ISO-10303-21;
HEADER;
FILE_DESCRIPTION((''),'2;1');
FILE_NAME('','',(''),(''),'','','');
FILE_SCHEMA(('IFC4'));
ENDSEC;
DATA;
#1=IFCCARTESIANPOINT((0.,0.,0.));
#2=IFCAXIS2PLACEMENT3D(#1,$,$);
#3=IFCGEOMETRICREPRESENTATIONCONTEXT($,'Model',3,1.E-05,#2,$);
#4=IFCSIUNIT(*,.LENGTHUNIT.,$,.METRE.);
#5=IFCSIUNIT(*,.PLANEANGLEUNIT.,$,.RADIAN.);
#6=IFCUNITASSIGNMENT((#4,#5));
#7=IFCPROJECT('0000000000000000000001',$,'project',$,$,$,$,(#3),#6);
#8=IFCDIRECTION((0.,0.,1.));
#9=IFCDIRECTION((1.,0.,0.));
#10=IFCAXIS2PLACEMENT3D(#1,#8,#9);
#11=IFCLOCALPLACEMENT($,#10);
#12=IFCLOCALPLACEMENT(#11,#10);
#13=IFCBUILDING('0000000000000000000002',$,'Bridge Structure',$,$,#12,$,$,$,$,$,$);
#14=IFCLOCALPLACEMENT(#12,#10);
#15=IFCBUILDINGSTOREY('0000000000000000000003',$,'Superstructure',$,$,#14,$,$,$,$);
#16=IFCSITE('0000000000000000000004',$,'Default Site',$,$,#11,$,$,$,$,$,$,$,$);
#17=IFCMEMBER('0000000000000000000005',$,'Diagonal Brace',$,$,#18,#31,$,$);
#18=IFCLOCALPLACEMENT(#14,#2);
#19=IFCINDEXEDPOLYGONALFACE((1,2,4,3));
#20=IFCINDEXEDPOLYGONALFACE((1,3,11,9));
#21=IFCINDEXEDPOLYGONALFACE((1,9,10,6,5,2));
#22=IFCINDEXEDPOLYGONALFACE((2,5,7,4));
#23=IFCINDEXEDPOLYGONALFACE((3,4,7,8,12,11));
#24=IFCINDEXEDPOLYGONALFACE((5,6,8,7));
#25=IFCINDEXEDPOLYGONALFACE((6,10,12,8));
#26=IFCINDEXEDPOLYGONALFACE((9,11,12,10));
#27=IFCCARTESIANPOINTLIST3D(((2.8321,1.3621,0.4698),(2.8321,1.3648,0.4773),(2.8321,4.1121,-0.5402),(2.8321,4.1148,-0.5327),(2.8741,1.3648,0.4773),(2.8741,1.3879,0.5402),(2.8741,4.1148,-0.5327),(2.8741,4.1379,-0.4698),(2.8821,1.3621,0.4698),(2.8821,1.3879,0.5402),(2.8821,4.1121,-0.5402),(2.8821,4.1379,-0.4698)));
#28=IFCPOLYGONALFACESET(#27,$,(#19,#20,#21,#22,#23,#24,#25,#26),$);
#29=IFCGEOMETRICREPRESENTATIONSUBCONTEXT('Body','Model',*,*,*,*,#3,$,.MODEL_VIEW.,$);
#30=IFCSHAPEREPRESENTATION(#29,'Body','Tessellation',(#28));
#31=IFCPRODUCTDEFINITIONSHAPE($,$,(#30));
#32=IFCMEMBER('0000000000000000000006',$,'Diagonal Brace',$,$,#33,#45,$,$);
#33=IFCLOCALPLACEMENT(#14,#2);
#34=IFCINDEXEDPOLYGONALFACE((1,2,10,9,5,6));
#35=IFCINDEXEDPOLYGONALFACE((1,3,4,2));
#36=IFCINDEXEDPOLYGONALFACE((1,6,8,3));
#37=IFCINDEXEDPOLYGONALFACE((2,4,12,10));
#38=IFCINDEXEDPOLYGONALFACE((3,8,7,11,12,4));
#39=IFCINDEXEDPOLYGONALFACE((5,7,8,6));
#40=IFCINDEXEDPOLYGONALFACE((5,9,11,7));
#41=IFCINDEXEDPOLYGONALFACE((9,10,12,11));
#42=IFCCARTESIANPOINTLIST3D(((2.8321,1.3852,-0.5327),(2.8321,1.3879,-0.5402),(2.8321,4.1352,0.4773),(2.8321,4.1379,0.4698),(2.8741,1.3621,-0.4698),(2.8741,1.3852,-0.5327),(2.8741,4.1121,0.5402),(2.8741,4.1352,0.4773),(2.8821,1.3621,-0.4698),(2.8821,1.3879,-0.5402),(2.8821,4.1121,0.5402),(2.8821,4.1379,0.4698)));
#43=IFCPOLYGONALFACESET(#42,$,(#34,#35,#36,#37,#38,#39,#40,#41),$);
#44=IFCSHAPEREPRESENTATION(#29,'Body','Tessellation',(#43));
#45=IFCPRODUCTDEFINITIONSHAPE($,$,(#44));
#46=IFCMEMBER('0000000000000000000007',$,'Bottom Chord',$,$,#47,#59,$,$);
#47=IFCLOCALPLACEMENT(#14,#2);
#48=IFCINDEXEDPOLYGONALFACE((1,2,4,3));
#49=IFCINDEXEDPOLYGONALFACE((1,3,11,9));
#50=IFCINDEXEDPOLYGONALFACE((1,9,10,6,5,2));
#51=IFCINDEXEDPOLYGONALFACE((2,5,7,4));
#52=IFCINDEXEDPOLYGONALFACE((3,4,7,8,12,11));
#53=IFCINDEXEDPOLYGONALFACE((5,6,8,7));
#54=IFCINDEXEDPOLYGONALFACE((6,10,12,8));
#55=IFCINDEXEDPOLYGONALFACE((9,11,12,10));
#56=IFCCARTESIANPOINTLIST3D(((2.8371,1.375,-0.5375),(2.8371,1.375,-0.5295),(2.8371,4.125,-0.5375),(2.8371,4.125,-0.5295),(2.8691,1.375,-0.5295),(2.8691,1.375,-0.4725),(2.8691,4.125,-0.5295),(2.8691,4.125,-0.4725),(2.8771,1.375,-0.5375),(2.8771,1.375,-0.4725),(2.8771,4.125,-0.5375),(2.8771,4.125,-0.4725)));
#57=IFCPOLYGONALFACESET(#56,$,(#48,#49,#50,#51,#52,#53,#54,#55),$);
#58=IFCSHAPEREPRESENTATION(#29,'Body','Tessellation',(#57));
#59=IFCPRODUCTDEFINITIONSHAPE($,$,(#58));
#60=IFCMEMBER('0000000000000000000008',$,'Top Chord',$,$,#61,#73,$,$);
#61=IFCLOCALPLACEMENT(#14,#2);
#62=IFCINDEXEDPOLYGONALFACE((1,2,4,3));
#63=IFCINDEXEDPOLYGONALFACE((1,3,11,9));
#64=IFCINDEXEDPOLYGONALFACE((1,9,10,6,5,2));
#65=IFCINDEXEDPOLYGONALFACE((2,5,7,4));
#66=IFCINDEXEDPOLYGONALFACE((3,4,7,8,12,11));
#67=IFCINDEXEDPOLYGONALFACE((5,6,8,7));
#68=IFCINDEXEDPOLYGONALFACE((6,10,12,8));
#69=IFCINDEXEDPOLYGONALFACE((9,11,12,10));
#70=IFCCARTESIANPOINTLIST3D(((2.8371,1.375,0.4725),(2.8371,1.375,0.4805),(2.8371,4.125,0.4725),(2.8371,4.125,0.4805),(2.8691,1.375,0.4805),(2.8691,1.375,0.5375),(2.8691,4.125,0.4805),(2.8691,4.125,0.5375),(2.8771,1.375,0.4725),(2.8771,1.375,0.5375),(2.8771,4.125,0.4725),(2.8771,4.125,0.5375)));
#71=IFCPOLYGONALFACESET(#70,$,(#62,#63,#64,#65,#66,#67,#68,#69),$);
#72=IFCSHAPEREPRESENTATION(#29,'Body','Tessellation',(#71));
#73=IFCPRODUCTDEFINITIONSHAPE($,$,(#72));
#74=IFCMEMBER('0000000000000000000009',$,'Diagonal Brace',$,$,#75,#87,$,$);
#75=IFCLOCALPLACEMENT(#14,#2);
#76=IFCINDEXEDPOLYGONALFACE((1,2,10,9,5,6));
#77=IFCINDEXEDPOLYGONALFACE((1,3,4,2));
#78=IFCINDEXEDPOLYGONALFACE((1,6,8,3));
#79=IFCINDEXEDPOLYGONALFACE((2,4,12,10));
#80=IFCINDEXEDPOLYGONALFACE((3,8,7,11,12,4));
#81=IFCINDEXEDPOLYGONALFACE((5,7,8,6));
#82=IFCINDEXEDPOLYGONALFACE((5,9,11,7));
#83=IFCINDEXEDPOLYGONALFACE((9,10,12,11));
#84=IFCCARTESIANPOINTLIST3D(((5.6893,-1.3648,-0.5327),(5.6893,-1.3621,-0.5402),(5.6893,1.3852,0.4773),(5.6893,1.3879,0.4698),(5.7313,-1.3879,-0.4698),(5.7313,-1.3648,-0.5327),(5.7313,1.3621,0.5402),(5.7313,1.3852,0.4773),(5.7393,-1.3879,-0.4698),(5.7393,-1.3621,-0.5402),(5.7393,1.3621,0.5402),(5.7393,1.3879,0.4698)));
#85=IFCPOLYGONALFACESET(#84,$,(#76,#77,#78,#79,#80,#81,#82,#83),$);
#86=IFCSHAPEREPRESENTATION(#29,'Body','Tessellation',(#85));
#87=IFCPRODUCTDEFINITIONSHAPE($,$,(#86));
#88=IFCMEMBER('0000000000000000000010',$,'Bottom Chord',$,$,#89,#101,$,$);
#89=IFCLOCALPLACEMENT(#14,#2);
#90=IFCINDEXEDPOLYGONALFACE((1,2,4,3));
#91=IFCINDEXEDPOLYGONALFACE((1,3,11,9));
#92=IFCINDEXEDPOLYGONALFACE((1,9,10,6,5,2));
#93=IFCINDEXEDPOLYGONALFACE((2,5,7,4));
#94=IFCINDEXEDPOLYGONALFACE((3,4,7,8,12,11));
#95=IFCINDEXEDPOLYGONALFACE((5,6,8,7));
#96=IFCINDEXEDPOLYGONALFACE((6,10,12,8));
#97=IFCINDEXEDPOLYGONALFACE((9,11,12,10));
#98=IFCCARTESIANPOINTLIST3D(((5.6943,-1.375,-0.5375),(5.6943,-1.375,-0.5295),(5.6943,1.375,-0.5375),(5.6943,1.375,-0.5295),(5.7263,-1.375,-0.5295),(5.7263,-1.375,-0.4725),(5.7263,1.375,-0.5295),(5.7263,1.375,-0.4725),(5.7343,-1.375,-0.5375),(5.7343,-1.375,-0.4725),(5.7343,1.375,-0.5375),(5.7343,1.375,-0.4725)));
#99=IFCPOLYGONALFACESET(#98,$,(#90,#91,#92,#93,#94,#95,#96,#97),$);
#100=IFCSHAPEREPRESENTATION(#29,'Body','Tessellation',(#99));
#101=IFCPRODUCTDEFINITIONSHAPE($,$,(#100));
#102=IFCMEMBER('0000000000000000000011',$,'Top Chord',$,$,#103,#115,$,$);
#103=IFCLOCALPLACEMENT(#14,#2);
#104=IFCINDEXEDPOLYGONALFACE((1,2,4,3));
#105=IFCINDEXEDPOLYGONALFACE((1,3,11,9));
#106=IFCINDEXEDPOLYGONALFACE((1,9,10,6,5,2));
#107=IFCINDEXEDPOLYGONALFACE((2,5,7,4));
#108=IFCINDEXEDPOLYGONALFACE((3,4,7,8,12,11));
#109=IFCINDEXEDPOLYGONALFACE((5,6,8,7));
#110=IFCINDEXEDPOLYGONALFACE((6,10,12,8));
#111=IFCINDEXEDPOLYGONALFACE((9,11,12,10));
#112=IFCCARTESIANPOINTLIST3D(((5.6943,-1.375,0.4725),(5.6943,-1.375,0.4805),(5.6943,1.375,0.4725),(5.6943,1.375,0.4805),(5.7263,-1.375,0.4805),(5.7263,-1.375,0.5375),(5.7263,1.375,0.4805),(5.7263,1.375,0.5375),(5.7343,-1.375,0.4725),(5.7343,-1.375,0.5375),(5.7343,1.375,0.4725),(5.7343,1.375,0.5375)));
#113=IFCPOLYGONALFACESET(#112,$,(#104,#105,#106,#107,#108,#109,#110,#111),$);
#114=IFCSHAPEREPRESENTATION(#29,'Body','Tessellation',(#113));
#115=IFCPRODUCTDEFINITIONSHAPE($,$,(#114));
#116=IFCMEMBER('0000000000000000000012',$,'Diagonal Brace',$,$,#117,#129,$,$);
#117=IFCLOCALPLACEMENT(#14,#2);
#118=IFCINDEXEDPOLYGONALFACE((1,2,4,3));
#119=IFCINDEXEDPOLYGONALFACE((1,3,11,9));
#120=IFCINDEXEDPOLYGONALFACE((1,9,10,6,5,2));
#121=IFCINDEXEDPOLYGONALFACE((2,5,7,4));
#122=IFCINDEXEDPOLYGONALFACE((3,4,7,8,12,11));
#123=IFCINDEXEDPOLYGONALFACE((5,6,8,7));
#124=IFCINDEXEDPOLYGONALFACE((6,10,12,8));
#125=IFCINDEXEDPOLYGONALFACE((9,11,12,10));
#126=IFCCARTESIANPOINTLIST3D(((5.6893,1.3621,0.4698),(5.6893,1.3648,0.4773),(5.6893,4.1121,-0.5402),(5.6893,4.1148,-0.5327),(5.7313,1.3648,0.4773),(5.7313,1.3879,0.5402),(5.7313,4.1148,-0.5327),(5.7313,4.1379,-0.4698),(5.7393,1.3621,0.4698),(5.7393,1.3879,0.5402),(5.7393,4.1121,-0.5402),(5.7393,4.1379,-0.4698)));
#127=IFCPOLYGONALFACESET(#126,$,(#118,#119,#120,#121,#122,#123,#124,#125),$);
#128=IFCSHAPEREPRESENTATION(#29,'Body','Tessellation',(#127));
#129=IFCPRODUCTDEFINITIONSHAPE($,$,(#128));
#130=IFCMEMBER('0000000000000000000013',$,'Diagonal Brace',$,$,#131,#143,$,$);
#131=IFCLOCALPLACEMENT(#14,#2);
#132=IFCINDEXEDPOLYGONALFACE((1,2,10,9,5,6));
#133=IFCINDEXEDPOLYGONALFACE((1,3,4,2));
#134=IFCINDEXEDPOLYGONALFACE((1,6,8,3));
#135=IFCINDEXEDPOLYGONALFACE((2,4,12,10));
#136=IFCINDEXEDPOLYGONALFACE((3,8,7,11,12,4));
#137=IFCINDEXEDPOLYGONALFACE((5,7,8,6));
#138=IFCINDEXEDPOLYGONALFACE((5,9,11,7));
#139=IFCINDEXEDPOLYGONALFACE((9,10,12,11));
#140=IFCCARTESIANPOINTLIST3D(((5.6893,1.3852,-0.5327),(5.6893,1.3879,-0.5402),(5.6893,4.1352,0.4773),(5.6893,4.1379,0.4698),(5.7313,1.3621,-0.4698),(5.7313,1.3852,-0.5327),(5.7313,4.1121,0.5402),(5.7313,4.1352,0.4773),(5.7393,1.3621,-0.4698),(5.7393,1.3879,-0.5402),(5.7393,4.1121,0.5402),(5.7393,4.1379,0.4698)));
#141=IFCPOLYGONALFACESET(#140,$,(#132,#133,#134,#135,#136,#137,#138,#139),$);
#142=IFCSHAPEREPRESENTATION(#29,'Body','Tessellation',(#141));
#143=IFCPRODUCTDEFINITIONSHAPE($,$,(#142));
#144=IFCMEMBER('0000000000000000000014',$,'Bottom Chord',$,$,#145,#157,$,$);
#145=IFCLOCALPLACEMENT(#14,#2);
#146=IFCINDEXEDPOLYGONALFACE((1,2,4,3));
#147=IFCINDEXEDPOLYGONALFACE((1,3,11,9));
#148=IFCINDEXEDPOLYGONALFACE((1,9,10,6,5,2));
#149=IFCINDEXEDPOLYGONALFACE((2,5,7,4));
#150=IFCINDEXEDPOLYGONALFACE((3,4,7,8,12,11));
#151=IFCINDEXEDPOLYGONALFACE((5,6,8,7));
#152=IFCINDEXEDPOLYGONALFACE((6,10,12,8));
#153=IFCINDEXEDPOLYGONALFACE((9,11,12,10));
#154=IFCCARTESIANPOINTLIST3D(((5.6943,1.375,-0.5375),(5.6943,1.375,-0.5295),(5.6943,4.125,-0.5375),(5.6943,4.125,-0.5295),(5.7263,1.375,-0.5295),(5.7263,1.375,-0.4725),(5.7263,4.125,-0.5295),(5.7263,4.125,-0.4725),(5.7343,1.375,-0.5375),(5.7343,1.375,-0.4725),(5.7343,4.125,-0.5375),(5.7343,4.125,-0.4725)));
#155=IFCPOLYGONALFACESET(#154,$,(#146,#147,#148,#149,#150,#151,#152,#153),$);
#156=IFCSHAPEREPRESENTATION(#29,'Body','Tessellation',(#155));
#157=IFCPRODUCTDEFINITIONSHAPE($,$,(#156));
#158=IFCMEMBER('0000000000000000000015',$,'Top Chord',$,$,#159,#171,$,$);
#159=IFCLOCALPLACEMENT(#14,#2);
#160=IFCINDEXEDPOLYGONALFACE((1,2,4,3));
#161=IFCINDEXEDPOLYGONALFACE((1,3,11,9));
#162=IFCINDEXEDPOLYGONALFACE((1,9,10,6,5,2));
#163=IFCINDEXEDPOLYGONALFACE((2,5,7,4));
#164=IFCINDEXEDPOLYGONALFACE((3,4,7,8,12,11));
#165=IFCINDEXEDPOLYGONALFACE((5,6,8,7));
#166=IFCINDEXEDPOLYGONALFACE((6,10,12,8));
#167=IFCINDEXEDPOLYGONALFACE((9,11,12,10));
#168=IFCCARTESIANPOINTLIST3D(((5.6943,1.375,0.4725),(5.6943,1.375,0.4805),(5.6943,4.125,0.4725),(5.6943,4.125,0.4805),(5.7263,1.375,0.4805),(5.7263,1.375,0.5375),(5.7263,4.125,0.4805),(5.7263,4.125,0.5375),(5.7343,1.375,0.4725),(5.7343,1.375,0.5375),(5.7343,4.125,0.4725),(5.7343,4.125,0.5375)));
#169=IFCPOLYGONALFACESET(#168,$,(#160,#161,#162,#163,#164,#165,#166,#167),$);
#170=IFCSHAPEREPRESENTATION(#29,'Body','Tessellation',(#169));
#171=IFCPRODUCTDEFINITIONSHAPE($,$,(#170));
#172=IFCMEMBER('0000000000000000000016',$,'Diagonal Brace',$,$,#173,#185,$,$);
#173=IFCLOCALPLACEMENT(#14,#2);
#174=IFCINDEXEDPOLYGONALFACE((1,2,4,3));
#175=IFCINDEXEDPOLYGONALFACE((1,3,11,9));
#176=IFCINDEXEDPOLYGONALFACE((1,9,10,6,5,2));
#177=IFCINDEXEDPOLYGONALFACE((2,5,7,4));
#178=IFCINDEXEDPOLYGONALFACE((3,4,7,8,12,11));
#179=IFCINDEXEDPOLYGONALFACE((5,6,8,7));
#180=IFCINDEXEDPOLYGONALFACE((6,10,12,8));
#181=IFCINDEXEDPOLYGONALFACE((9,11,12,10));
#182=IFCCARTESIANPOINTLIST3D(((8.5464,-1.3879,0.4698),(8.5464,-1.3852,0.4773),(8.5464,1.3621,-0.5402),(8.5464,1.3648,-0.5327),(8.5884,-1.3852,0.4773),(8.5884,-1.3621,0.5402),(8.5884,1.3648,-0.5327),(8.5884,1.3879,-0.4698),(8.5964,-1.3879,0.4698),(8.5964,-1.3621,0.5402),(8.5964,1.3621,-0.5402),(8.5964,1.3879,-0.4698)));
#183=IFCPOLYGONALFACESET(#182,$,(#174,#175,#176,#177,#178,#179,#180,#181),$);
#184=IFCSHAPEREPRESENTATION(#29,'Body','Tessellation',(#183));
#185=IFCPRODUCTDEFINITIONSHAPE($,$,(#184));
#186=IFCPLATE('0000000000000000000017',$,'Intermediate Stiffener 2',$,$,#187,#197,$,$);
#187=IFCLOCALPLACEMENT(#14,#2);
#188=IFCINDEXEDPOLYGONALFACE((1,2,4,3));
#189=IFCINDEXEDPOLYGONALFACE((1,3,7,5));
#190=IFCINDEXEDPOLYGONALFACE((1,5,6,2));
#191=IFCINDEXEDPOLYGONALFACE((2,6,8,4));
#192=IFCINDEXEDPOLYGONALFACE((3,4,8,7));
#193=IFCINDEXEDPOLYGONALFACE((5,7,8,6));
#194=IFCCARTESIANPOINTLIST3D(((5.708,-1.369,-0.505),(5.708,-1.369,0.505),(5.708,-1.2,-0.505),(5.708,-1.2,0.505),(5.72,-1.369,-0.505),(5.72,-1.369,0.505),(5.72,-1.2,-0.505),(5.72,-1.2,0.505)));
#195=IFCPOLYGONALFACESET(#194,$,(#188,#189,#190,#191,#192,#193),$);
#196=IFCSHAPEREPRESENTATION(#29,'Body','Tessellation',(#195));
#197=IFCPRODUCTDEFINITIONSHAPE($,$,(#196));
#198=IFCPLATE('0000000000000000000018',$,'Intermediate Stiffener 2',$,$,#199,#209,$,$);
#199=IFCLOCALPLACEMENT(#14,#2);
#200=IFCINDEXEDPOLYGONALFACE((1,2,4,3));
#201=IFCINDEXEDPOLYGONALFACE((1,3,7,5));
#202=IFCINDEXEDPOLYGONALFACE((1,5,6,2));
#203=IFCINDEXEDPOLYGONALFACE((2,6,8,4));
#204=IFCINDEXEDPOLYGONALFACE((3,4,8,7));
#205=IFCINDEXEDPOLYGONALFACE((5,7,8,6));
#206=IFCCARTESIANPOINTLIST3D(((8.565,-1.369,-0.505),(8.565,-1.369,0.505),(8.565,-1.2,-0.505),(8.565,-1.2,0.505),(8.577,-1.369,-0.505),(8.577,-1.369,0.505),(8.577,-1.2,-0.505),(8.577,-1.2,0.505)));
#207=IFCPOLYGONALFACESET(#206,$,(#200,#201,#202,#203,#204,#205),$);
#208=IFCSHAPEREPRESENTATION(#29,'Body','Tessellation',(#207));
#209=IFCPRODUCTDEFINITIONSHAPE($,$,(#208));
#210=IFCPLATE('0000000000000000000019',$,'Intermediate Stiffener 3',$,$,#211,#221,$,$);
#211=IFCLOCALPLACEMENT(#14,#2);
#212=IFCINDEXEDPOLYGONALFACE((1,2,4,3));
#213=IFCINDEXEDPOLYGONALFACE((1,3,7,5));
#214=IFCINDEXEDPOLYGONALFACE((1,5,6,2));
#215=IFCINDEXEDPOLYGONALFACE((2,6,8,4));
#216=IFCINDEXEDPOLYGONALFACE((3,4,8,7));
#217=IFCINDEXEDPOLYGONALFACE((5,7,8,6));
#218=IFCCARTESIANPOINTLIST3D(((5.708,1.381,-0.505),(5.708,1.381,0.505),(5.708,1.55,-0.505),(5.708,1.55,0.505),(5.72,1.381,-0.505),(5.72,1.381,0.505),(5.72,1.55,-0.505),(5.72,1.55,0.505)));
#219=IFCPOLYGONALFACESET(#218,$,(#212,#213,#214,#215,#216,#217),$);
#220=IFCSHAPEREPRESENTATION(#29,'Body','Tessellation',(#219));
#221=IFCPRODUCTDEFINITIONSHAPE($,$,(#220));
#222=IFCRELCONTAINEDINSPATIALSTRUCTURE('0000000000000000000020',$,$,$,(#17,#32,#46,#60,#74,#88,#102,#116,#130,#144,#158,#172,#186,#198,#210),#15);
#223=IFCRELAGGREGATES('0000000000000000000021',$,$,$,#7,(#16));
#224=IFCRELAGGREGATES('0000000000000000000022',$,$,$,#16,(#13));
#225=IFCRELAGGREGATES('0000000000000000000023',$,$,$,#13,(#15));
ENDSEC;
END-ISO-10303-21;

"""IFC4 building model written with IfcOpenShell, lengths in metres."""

from ifc_helpers import new_model, si_unit, frame, origin, origin_with_axes, origin_2d_with_axis, place, context, subcontext, project, spatial, rectangle, l_section, extrude, element, save


model = new_model("IFC4")

# Units and contexts
model_context = context("Model", 3, precision=1e-05, world=origin())
body_context = subcontext(model_context, "Body", "Model", "MODEL_VIEW")
ifc_project = project(units=[si_unit("LENGTHUNIT", "METRE"), si_unit("PLANEANGLEUNIT", "RADIAN")], contexts=[model_context])

# Site, building, storey
site_placement = place(None, origin_with_axes())
site = spatial("IfcSite", under=ifc_project, at=site_placement, Name="Default Site")
building_placement = place(site_placement, origin_with_axes())
building = spatial("IfcBuilding", under=site, at=building_placement, Name="Bridge Structure")
storey_placement = place(building_placement, origin_with_axes())
storey = spatial("IfcBuildingStorey", under=building, at=storey_placement, Name="Superstructure")

# Members
for number, where, z_axis, x_axis, name in (
    (1, (2.8571, 1.375, 0.505), (0.0, 0.938692, -0.344756), (-1.0, 0.0, 0.0), "Diagonal Brace"),
    (2, (2.8571, 1.375, -0.505), (0.0, 0.938692, 0.344756), (-1.0, 0.0, 0.0), "Diagonal Brace"),
):
    element("IfcMember", number, at=place(storey_placement, frame(where, z_axis=z_axis, x_axis=x_axis)), inside=storey, Name=name, context=body_context, shape_type="SweptSolid", body=[
        extrude(l_section(Depth=0.075, Width=0.05, Thickness=0.008, at=origin_2d_with_axis()), origin_with_axes(), (0.0, 0.0, 1.0), 2.9296),
    ])
for number, where, z_axis, x_axis, name in (
    (3, (2.8571, 1.375, -0.505), (0.0, 1.0, 0.0), (-1.0, 0.0, 0.0), "Bottom Chord"),
    (4, (2.8571, 1.375, 0.505), (0.0, 1.0, 0.0), (-1.0, 0.0, 0.0), "Top Chord"),
):
    element("IfcMember", number, at=place(storey_placement, frame(where, z_axis=z_axis, x_axis=x_axis)), inside=storey, Name=name, context=body_context, shape_type="SweptSolid", body=[
        extrude(l_section(Depth=0.065, Width=0.04, Thickness=0.008, at=origin_2d_with_axis()), origin_with_axes(), (0.0, 0.0, 1.0), 2.75),
    ])
member_1_placement = place(storey_placement, frame((5.7143, -1.375, -0.505), z_axis=(0.0, 0.938692, 0.344756), x_axis=(-1.0, 0.0, 0.0)))
element("IfcMember", 5, at=member_1_placement, inside=storey, Name="Diagonal Brace", context=body_context, shape_type="SweptSolid", body=[
    extrude(l_section(Depth=0.075, Width=0.05, Thickness=0.008, at=origin_2d_with_axis()), origin_with_axes(), (0.0, 0.0, 1.0), 2.9296),
])
for number, where, z_axis, x_axis, name in (
    (6, (5.7143, -1.375, -0.505), (0.0, 1.0, 0.0), (-1.0, 0.0, 0.0), "Bottom Chord"),
    (7, (5.7143, -1.375, 0.505), (0.0, 1.0, 0.0), (-1.0, 0.0, 0.0), "Top Chord"),
):
    element("IfcMember", number, at=place(storey_placement, frame(where, z_axis=z_axis, x_axis=x_axis)), inside=storey, Name=name, context=body_context, shape_type="SweptSolid", body=[
        extrude(l_section(Depth=0.065, Width=0.04, Thickness=0.008, at=origin_2d_with_axis()), origin_with_axes(), (0.0, 0.0, 1.0), 2.75),
    ])
for number, where, z_axis, x_axis, name in (
    (8, (5.7143, 1.375, 0.505), (0.0, 0.938692, -0.344756), (-1.0, 0.0, 0.0), "Diagonal Brace"),
    (9, (5.7143, 1.375, -0.505), (0.0, 0.938692, 0.344756), (-1.0, 0.0, 0.0), "Diagonal Brace"),
):
    element("IfcMember", number, at=place(storey_placement, frame(where, z_axis=z_axis, x_axis=x_axis)), inside=storey, Name=name, context=body_context, shape_type="SweptSolid", body=[
        extrude(l_section(Depth=0.075, Width=0.05, Thickness=0.008, at=origin_2d_with_axis()), origin_with_axes(), (0.0, 0.0, 1.0), 2.9296),
    ])
for number, where, z_axis, x_axis, name in (
    (10, (5.7143, 1.375, -0.505), (0.0, 1.0, 0.0), (-1.0, 0.0, 0.0), "Bottom Chord"),
    (11, (5.7143, 1.375, 0.505), (0.0, 1.0, 0.0), (-1.0, 0.0, 0.0), "Top Chord"),
):
    element("IfcMember", number, at=place(storey_placement, frame(where, z_axis=z_axis, x_axis=x_axis)), inside=storey, Name=name, context=body_context, shape_type="SweptSolid", body=[
        extrude(l_section(Depth=0.065, Width=0.04, Thickness=0.008, at=origin_2d_with_axis()), origin_with_axes(), (0.0, 0.0, 1.0), 2.75),
    ])
member_2_placement = place(storey_placement, frame((8.5714, -1.375, 0.505), z_axis=(0.0, 0.938692, -0.344756), x_axis=(-1.0, 0.0, 0.0)))
element("IfcMember", 12, at=member_2_placement, inside=storey, Name="Diagonal Brace", context=body_context, shape_type="SweptSolid", body=[
    extrude(l_section(Depth=0.075, Width=0.05, Thickness=0.008, at=origin_2d_with_axis()), origin_with_axes(), (0.0, 0.0, 1.0), 2.9296),
])

# Plates
for number, where, z_axis, x_axis, name in (
    (13, (5.714, -1.2845, -0.505), (0.0, 0.0, 1.0), (1.0, 0.0, 0.0), "Intermediate Stiffener 2"),
    (14, (8.571, -1.2845, -0.505), (0.0, 0.0, 1.0), (1.0, 0.0, 0.0), "Intermediate Stiffener 2"),
    (15, (5.714, 1.4655, -0.505), (0.0, 0.0, 1.0), (1.0, 0.0, 0.0), "Intermediate Stiffener 3"),
):
    element("IfcPlate", number, at=place(storey_placement, frame(where, z_axis=z_axis, x_axis=x_axis)), inside=storey, Name=name, context=body_context, shape_type="SweptSolid", body=[
        extrude(rectangle(XDim=0.012, YDim=0.169, at=origin_2d_with_axis()), origin_with_axes(), (0.0, 0.0, 1.0), 1.01),
    ])

save(model, "model.ifc")
